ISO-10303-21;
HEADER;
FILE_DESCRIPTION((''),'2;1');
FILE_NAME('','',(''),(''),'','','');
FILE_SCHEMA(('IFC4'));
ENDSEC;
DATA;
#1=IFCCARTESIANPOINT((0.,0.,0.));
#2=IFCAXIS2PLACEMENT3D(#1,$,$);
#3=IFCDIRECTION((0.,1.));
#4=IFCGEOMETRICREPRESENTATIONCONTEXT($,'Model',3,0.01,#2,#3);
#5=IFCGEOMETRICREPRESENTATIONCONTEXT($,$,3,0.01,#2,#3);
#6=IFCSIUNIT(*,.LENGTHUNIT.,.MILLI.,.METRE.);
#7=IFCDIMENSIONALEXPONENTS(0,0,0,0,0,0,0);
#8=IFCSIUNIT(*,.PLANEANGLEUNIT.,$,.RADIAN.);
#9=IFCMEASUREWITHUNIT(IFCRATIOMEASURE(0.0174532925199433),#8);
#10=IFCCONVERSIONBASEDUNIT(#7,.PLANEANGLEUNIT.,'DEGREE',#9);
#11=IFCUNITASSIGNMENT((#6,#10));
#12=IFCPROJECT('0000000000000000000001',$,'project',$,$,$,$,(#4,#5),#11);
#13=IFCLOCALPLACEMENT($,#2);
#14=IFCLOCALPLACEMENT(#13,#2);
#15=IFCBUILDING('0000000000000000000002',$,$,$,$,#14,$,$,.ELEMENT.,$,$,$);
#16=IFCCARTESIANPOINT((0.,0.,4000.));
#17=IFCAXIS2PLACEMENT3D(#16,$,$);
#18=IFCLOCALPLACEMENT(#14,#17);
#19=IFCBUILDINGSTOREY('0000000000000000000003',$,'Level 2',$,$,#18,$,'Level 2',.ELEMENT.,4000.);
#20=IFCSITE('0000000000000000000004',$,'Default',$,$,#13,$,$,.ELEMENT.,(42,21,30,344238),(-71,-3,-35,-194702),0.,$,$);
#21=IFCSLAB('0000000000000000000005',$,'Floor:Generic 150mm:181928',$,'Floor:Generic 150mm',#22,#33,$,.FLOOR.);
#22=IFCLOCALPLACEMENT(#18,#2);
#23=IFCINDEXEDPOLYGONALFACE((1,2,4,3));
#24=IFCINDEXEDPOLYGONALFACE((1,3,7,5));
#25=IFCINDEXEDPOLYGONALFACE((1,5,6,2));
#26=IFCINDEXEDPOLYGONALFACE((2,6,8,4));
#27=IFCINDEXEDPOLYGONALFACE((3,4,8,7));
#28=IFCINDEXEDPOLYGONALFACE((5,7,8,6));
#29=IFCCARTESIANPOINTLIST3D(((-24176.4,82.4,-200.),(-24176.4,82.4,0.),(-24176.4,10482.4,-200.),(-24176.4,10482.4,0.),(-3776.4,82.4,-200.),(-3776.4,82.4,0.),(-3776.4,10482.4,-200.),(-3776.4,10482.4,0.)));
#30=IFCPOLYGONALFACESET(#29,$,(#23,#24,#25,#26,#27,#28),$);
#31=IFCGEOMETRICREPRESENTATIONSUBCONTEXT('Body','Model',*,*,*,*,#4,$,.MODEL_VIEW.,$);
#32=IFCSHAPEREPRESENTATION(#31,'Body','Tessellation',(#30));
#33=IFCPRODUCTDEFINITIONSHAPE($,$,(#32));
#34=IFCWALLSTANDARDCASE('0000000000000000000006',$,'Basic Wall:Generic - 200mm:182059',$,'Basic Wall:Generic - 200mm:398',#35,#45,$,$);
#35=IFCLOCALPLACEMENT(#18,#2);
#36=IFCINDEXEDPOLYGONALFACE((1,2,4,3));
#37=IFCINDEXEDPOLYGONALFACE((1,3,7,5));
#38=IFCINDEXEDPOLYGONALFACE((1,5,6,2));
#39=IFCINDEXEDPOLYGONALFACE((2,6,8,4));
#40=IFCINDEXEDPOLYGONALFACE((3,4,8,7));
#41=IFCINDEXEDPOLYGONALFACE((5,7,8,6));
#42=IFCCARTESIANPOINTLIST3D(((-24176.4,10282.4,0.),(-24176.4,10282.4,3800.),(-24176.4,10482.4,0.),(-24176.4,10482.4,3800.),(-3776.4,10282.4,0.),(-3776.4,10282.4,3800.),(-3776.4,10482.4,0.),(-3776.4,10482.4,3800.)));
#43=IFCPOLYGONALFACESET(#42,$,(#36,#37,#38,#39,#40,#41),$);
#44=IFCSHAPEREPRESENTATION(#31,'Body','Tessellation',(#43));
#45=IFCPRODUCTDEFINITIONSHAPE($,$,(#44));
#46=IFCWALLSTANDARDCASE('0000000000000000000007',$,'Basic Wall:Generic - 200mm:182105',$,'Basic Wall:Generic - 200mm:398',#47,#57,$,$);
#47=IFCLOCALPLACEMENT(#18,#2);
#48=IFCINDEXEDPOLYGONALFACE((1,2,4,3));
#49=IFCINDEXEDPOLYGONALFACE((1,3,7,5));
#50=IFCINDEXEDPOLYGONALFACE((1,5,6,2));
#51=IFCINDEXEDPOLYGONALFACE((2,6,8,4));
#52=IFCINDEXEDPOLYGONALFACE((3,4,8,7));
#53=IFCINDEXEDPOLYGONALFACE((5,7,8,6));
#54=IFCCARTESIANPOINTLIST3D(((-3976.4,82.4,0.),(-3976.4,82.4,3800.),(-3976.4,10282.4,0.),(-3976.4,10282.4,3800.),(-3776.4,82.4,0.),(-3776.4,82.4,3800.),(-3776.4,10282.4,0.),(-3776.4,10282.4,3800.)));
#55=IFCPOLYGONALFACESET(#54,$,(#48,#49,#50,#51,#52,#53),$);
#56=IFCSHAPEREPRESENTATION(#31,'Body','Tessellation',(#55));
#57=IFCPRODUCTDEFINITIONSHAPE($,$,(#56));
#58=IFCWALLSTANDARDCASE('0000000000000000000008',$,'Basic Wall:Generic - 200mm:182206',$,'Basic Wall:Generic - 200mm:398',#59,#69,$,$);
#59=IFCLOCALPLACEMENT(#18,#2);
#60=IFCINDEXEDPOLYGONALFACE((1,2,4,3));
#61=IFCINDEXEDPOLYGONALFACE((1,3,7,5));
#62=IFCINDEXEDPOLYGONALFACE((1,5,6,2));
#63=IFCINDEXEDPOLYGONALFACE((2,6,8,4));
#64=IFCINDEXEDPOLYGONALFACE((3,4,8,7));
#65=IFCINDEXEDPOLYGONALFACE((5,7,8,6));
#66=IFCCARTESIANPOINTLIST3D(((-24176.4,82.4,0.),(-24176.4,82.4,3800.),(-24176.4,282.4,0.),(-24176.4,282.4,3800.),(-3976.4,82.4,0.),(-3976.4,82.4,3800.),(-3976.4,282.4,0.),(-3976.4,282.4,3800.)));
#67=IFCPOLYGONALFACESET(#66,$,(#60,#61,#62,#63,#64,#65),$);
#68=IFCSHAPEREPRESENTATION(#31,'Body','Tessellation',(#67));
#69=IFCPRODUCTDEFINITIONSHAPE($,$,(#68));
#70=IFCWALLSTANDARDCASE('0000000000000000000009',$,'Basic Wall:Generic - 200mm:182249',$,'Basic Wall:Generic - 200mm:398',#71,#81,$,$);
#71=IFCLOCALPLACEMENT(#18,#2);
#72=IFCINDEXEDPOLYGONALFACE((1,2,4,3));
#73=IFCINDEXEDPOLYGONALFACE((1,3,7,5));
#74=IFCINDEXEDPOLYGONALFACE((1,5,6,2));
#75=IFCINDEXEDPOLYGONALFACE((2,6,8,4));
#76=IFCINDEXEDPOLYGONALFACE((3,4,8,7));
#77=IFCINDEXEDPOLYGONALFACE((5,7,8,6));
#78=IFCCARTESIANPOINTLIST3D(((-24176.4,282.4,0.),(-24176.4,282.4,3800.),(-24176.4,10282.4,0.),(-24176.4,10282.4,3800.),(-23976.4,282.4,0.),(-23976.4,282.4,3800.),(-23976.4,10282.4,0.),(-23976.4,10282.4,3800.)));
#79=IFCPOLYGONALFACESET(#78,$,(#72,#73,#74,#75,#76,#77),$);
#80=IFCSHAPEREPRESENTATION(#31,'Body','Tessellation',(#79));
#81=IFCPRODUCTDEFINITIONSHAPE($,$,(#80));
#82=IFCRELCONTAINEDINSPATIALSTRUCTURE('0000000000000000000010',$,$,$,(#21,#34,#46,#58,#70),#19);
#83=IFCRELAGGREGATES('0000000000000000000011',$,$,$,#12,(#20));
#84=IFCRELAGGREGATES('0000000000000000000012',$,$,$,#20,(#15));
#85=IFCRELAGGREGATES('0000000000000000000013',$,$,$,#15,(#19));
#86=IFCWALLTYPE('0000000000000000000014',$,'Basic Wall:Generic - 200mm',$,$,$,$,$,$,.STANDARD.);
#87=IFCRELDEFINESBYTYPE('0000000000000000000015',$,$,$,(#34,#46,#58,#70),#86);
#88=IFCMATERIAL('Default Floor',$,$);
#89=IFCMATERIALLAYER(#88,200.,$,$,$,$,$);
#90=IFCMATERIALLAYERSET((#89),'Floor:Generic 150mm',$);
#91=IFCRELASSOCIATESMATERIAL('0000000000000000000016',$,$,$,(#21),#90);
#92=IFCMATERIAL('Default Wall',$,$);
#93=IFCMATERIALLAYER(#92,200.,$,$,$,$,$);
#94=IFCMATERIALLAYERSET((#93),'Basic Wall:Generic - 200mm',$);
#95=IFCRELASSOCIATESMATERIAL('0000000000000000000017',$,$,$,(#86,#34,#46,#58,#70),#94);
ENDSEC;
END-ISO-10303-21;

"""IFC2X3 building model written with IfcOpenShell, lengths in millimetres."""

from ifc_helpers import new_model, entity, si_unit, converted_unit, direction, frame, frame_2d, origin, origin_2d_with_axis, place, context, subcontext, project, spatial, rectangle, extrude, material, layer, layer_set, layer_usage, type_object, element, save


model = new_model("IFC2X3")

# Units and contexts
model_context = context("Model", 3, precision=0.01, world=origin(), true_north=direction((0.0, 1.0)))
context_of_model = context(None, 3, precision=0.01, world=origin(), true_north=direction((0.0, 1.0)))
body_context = subcontext(model_context, "Body", "Model", "MODEL_VIEW")
ifc_project = project(units=[si_unit("LENGTHUNIT", "METRE", prefix="MILLI"), converted_unit("PLANEANGLEUNIT", "DEGREE", entity("IfcRatioMeasure", 0.0174532925199433), si_unit("PLANEANGLEUNIT", "RADIAN"), dimensions=[0, 0, 0, 0, 0, 0, 0])], contexts=[model_context, context_of_model])

# Site, building, storey
site_placement = place(None, origin())
site = spatial("IfcSite", under=ifc_project, at=site_placement, Name="Default", CompositionType="ELEMENT", RefLatitude=(42, 21, 30, 344238), RefLongitude=(-71, -3, -35, -194702), RefElevation=0.0)
building_placement = place(site_placement, origin())
building = spatial("IfcBuilding", under=site, at=building_placement, CompositionType="ELEMENT")
storey_placement = place(building_placement, frame((0.0, 0.0, 4000.0)))
storey = spatial("IfcBuildingStorey", under=building, at=storey_placement, Name="Level 2", LongName="Level 2", CompositionType="ELEMENT", Elevation=4000.0)

# Slab
ifc_material_1 = material(Name="Default Floor")
ifc_layer_1 = layer(ifc_material_1, 200.0)
ifc_layer_set_1 = layer_set([ifc_layer_1], Name="Floor:Generic 150mm")
ifc_layer_usage_1 = layer_usage(ifc_layer_set_1, "AXIS3", "POSITIVE", 0.0)
slab_placement = place(storey_placement, origin())
element("IfcSlab", 1, at=slab_placement, inside=storey, material=ifc_layer_usage_1, Name="Floor:Generic 150mm:181928", ObjectType="Floor:Generic 150mm", PredefinedType="FLOOR", context=body_context, shape_type="SweptSolid", body=[
    extrude(rectangle(XDim=10400.0, YDim=20400.0, at=origin_2d_with_axis()), frame((-13976.4, 5282.4, 0.0), z_axis=(0.0, 0.0, -1.0), x_axis=(0.0, 1.0, 0.0)), (0.0, 0.0, 1.0), 200.0),
])

# Walls
ifc_material_2 = material(Name="Default Wall")
ifc_layer_2 = layer(ifc_material_2, 200.0)
ifc_layer_set_2 = layer_set([ifc_layer_2], Name="Basic Wall:Generic - 200mm")
ifc_layer_usage_2 = layer_usage(ifc_layer_set_2, "AXIS2", "NEGATIVE", 100.0)
wall_type = type_object("IfcWallType", Name="Basic Wall:Generic - 200mm", PredefinedType="STANDARD", material=ifc_layer_set_2)
wall_1_placement = place(storey_placement, frame((-24176.4, 10382.4, 0.0)))
element("IfcWallStandardCase", 2, at=wall_1_placement, inside=storey, type_object=wall_type, material=ifc_layer_usage_2, Name="Basic Wall:Generic - 200mm:182059", ObjectType="Basic Wall:Generic - 200mm:398", context=body_context, shape_type="SweptSolid", body=[
    extrude(rectangle(XDim=20400.0, YDim=200.0, at=frame_2d((10200.0, 0.0), x_axis=(-1.0, 0.0))), origin(), (0.0, 0.0, 1.0), 3800.0),
])
ifc_layer_usage_3 = layer_usage(ifc_layer_set_2, "AXIS2", "NEGATIVE", 100.0)
wall_2_placement = place(storey_placement, frame((-3876.4, 10282.4, 0.0), z_axis=(0.0, 0.0, 1.0), x_axis=(0.0, -1.0, 0.0)))
element("IfcWallStandardCase", 3, at=wall_2_placement, inside=storey, type_object=wall_type, material=ifc_layer_usage_3, Name="Basic Wall:Generic - 200mm:182105", ObjectType="Basic Wall:Generic - 200mm:398", context=body_context, shape_type="SweptSolid", body=[
    extrude(rectangle(XDim=10200.0, YDim=200.0, at=frame_2d((5100.0, 0.0), x_axis=(-1.0, 0.0))), origin(), (0.0, 0.0, 1.0), 3800.0),
])
ifc_layer_usage_4 = layer_usage(ifc_layer_set_2, "AXIS2", "NEGATIVE", 100.0)
wall_3_placement = place(storey_placement, frame((-3976.4, 182.4, 0.0), z_axis=(0.0, 0.0, 1.0), x_axis=(-1.0, 0.0, 0.0)))
element("IfcWallStandardCase", 4, at=wall_3_placement, inside=storey, type_object=wall_type, material=ifc_layer_usage_4, Name="Basic Wall:Generic - 200mm:182206", ObjectType="Basic Wall:Generic - 200mm:398", context=body_context, shape_type="SweptSolid", body=[
    extrude(rectangle(XDim=20200.0, YDim=200.0, at=frame_2d((10100.0, 0.0), x_axis=(-1.0, 0.0))), origin(), (0.0, 0.0, 1.0), 3800.0),
])
ifc_layer_usage_5 = layer_usage(ifc_layer_set_2, "AXIS2", "NEGATIVE", 100.0)
wall_4_placement = place(storey_placement, frame((-24076.4, 282.4, 0.0), z_axis=(0.0, 0.0, 1.0), x_axis=(0.0, 1.0, 0.0)))
element("IfcWallStandardCase", 5, at=wall_4_placement, inside=storey, type_object=wall_type, material=ifc_layer_usage_5, Name="Basic Wall:Generic - 200mm:182249", ObjectType="Basic Wall:Generic - 200mm:398", context=body_context, shape_type="SweptSolid", body=[
    extrude(rectangle(XDim=10000.0, YDim=200.0, at=frame_2d((5000.0, 0.0), x_axis=(-1.0, 0.0))), origin(), (0.0, 0.0, 1.0), 3800.0),
])

save(model, "model.ifc")
